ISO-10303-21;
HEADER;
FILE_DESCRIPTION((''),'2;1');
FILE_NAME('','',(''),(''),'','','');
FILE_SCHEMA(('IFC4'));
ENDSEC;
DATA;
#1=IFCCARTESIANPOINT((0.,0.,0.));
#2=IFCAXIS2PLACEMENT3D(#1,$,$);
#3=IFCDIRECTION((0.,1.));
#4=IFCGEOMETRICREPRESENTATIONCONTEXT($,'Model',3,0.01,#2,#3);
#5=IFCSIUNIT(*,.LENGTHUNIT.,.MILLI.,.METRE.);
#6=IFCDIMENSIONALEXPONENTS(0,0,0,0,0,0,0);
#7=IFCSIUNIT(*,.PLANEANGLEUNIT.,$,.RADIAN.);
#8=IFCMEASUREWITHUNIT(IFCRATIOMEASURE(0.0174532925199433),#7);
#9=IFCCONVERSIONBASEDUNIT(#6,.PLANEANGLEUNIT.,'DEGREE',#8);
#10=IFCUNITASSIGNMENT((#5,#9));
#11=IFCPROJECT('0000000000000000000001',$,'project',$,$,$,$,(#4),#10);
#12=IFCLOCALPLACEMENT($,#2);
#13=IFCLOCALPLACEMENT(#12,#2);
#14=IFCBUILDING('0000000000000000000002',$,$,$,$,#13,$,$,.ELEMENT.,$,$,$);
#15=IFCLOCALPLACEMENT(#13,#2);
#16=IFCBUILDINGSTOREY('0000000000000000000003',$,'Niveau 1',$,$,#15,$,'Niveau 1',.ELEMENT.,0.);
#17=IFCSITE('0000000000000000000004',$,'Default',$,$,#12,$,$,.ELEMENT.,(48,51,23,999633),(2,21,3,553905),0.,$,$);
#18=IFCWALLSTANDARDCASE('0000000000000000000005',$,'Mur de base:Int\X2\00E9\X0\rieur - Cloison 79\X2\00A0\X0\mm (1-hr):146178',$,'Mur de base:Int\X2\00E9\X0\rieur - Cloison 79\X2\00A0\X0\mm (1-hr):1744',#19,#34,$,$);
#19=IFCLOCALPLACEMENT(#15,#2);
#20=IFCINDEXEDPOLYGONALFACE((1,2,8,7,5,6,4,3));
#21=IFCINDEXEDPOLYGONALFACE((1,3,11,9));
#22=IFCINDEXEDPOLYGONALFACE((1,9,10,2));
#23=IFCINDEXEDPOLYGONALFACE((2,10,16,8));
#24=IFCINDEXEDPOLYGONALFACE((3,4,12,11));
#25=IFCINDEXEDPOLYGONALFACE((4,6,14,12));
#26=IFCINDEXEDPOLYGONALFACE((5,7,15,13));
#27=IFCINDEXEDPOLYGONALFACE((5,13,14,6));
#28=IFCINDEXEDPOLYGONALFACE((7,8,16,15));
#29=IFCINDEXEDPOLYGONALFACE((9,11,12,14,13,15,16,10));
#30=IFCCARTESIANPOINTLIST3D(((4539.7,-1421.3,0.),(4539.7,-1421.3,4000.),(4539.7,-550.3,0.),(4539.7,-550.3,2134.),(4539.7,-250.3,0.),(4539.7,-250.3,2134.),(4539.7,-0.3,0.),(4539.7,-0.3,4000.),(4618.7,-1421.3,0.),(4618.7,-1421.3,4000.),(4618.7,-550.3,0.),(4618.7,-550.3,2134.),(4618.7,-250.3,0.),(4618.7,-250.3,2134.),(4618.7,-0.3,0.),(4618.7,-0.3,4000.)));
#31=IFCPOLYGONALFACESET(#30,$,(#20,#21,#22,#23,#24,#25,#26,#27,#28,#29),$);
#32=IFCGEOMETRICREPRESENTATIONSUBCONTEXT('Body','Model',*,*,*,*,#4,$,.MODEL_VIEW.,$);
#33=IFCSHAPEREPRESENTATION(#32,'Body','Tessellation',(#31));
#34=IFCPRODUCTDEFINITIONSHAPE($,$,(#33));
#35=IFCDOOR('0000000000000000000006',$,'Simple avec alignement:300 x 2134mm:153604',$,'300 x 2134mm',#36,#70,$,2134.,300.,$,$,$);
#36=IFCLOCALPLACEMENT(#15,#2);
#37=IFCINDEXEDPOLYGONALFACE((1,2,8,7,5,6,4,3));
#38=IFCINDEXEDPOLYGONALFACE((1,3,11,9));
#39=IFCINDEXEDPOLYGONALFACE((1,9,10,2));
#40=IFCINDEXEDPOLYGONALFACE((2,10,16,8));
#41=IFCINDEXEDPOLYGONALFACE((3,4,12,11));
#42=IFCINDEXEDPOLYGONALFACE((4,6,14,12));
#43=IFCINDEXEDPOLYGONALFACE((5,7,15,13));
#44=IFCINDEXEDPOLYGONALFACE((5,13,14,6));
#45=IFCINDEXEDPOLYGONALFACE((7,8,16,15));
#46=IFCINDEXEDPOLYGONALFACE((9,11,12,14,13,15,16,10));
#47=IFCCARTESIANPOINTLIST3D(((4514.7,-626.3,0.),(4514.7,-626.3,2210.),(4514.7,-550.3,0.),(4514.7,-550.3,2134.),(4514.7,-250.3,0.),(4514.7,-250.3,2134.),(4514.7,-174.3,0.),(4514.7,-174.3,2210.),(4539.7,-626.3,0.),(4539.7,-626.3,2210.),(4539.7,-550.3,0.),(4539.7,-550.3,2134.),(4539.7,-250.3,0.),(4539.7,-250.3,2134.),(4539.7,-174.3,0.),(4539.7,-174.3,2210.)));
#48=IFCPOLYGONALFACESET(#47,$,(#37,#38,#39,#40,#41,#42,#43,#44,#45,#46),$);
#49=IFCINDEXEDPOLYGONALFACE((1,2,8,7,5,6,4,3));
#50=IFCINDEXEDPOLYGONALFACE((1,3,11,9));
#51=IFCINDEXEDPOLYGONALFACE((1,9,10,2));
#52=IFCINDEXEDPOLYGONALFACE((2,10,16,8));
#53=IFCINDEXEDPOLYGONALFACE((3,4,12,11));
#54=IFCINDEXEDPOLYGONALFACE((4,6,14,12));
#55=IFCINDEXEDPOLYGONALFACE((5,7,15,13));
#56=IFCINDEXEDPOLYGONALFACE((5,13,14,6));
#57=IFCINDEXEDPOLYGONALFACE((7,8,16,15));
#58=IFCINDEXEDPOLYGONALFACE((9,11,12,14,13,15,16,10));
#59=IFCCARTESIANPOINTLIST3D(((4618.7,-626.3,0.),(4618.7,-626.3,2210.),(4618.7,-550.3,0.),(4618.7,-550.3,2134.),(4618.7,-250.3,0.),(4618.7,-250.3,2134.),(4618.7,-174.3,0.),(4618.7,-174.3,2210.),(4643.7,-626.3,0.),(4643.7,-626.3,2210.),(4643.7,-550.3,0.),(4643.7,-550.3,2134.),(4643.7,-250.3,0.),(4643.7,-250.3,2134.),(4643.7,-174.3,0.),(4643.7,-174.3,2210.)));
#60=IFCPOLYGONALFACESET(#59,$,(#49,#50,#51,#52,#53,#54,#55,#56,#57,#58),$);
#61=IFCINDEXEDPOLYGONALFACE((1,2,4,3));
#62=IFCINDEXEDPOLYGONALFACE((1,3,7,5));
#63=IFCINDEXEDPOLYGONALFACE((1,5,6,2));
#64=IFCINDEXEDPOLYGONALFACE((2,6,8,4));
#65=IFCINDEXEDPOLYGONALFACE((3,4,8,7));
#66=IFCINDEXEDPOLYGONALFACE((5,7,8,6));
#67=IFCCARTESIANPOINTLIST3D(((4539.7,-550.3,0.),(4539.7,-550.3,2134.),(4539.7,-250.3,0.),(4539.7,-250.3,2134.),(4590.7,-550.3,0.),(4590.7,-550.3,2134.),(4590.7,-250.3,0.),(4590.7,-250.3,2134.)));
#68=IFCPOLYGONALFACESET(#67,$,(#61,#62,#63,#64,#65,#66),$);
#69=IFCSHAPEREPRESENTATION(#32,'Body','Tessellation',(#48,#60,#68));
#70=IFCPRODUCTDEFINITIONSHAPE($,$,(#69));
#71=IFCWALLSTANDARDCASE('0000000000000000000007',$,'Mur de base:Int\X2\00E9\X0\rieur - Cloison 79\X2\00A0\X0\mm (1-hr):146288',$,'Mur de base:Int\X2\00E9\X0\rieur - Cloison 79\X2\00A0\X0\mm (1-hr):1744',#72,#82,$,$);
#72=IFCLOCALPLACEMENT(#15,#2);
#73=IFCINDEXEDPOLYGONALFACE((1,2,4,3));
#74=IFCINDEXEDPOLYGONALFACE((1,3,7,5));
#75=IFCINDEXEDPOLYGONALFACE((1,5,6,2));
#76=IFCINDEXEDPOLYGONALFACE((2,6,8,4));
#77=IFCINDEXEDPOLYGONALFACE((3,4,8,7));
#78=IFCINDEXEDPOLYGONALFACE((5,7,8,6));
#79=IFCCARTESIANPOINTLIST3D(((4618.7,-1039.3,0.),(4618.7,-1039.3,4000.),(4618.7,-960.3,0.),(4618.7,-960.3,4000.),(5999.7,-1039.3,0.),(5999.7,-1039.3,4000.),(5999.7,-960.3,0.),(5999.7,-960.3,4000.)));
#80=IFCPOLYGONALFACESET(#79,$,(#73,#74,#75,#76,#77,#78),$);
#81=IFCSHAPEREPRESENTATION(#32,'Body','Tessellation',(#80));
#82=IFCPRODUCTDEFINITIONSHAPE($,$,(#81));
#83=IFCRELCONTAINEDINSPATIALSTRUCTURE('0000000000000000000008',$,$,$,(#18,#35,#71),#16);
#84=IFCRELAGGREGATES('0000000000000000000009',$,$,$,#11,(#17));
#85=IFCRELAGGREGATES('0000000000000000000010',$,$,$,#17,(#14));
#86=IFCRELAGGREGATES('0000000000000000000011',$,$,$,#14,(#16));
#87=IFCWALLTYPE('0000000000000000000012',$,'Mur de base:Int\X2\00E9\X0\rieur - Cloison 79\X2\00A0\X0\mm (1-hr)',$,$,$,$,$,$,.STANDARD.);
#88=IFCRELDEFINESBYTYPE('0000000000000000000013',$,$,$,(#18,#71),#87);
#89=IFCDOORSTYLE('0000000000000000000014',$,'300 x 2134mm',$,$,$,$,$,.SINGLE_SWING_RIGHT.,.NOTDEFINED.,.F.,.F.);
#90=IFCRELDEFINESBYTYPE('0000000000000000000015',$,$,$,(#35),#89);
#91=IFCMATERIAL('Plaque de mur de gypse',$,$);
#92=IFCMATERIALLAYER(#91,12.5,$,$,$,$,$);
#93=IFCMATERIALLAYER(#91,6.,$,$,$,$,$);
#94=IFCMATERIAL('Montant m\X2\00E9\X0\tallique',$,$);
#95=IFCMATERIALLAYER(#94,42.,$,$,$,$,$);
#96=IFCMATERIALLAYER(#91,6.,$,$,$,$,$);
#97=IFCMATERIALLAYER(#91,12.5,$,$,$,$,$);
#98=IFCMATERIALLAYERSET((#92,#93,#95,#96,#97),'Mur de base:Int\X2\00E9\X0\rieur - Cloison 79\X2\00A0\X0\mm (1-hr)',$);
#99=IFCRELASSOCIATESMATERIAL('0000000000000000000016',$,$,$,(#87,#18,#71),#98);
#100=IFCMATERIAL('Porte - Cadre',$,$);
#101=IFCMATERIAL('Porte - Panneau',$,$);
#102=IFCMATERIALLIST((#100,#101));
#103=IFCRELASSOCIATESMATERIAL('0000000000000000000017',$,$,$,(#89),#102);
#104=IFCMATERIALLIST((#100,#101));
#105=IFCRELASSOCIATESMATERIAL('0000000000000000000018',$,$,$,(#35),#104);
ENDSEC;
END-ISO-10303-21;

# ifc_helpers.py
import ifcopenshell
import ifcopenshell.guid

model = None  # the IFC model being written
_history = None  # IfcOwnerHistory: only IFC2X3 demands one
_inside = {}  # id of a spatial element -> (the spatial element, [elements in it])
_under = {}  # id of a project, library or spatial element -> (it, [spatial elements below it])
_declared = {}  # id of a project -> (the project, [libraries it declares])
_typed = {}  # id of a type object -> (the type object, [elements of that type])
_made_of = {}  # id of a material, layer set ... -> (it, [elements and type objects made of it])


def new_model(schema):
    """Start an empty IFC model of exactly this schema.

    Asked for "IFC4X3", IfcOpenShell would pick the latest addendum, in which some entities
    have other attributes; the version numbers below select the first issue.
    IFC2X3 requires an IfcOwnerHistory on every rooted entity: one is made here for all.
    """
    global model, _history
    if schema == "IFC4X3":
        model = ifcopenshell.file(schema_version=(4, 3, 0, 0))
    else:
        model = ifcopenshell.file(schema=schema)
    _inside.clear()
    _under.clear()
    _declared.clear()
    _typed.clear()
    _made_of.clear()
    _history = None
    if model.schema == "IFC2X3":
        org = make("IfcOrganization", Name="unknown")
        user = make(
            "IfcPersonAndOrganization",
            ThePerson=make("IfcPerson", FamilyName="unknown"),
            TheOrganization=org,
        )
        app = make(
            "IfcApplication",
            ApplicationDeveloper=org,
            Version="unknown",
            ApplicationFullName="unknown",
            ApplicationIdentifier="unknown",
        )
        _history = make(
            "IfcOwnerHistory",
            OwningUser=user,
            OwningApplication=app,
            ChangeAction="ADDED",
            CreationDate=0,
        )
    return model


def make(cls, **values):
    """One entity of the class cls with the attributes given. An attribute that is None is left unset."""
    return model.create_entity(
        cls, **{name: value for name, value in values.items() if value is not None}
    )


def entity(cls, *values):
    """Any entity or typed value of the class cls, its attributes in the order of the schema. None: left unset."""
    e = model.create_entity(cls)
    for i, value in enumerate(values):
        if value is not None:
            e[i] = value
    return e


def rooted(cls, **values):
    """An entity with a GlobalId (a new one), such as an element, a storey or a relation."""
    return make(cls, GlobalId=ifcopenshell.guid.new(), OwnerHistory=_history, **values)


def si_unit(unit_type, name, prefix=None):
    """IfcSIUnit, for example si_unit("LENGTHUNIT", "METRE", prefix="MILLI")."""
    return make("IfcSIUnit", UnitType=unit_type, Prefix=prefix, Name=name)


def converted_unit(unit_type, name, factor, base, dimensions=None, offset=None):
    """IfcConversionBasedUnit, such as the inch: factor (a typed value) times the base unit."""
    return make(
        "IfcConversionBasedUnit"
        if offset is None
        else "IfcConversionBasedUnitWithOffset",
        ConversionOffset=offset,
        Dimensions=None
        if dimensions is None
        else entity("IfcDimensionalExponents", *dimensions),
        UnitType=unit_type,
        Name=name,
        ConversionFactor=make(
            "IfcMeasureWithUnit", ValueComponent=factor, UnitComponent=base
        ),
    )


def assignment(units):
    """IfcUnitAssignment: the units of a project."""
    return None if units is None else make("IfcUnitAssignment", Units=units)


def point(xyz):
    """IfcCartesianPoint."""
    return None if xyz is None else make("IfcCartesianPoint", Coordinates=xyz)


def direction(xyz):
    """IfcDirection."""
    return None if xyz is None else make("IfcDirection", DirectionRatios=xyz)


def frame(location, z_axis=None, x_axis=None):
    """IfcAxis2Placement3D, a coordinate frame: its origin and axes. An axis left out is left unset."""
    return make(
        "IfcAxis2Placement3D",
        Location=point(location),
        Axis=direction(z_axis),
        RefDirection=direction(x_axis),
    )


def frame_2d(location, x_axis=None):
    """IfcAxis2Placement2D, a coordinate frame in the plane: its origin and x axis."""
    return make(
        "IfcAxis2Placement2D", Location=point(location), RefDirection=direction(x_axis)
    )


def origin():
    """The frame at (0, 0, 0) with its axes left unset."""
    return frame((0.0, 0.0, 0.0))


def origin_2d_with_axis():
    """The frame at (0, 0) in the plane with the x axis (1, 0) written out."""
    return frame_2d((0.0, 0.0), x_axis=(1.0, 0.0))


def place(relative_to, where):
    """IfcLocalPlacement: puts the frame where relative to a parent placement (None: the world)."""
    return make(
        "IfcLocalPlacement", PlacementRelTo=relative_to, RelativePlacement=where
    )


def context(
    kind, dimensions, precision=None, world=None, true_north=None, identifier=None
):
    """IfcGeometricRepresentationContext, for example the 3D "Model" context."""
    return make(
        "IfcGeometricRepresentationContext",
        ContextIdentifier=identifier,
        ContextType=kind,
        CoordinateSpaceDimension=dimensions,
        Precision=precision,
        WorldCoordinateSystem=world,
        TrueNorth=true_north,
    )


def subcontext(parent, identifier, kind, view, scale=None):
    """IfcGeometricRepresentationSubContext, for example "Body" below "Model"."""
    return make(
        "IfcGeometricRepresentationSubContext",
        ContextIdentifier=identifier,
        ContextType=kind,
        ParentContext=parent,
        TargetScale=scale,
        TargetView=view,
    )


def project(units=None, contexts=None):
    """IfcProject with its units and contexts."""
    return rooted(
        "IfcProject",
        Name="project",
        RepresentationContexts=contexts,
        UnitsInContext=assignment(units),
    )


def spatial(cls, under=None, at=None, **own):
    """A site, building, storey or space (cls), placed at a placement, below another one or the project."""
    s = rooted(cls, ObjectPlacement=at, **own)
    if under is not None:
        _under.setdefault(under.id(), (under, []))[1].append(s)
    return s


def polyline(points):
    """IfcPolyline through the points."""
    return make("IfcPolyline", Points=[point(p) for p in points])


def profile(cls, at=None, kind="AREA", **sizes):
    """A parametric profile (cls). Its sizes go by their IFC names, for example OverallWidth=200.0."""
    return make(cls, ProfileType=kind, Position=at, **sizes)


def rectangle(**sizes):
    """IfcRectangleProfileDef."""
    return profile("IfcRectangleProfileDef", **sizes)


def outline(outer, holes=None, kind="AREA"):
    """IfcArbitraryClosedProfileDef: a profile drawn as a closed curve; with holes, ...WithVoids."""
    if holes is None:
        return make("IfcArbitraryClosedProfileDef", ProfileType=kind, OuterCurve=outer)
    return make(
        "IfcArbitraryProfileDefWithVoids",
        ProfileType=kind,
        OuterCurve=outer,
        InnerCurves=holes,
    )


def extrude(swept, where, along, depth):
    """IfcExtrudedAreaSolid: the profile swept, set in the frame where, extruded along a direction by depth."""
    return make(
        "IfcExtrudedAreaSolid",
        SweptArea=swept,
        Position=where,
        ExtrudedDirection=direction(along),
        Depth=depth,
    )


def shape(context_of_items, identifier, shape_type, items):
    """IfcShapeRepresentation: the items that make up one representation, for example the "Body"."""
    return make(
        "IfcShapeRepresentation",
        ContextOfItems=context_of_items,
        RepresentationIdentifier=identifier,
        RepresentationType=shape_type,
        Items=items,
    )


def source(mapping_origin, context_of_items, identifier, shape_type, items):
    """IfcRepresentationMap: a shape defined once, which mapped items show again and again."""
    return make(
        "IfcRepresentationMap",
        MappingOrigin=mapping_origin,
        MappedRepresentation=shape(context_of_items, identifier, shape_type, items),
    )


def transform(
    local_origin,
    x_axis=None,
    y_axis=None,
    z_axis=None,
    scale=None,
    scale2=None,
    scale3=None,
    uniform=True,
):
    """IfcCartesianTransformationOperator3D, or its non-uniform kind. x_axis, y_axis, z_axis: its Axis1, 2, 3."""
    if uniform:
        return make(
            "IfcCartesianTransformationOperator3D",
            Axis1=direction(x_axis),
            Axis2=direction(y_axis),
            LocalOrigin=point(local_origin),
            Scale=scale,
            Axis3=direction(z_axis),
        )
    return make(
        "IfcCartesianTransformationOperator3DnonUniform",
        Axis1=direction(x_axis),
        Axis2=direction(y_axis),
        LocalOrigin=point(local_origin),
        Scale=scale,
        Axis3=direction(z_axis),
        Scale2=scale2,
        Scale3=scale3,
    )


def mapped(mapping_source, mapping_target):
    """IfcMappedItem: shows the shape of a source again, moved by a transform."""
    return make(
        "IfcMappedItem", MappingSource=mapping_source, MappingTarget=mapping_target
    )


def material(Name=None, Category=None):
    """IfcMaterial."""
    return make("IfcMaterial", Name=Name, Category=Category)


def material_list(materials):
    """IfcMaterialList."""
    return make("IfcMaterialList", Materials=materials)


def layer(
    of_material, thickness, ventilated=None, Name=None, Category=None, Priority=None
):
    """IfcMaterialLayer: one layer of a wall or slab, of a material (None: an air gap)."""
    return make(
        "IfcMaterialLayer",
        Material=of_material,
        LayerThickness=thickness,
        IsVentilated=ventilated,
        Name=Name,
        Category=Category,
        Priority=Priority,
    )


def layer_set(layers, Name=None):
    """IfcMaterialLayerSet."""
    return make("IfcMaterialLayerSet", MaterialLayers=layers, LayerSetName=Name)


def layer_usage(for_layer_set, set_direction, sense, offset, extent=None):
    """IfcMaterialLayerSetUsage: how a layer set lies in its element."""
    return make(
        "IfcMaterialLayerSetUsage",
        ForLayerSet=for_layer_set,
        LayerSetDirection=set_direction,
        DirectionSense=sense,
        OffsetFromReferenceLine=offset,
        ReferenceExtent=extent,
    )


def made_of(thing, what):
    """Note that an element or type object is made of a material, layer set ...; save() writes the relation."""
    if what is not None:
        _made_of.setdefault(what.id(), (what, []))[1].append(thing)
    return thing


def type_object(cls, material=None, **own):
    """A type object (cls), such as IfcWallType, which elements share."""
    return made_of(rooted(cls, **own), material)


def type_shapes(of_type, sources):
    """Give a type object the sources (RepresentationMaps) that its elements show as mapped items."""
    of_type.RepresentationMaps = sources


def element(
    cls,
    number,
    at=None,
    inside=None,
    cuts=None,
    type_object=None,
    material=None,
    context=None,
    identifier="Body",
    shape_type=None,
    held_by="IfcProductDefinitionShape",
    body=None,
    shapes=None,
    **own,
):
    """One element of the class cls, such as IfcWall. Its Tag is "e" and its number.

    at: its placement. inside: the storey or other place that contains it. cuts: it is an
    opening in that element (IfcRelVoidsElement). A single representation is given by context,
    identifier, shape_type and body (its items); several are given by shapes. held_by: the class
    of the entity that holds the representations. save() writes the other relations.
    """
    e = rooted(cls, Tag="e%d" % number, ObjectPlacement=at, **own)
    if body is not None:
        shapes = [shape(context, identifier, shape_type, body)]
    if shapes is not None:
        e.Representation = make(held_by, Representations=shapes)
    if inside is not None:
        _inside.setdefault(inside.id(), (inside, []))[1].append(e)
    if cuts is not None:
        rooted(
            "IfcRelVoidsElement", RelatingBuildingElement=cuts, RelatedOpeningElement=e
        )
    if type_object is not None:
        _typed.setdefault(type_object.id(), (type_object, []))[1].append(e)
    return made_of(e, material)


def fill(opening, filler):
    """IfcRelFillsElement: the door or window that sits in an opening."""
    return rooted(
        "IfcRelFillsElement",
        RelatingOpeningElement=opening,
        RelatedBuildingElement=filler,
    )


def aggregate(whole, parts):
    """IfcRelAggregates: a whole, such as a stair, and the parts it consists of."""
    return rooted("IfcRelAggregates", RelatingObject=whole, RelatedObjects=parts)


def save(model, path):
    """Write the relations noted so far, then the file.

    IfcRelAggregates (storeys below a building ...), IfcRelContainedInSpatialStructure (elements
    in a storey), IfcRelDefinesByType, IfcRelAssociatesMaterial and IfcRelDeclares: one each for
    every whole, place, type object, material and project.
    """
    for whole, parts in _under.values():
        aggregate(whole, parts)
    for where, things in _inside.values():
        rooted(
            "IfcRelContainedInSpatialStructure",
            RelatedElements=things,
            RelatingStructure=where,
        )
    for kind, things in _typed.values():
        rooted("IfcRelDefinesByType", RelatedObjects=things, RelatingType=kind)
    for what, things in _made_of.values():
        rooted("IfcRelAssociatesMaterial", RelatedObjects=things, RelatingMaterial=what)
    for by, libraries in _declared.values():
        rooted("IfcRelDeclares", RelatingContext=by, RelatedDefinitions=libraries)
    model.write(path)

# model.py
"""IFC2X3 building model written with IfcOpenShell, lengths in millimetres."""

from ifc_helpers import new_model, entity, si_unit, converted_unit, direction, frame, frame_2d, origin, origin_2d_with_axis, place, context, subcontext, project, spatial, polyline, rectangle, outline, extrude, source, transform, mapped, material, material_list, layer, layer_set, layer_usage, type_object, type_shapes, element, fill, save


model = new_model("IFC2X3")

# Units and contexts
model_context = context("Model", 3, precision=0.01, world=origin(), true_north=direction((0.0, 1.0)))
body_context = subcontext(model_context, "Body", "Model", "MODEL_VIEW")
ifc_project = project(units=[si_unit("LENGTHUNIT", "METRE", prefix="MILLI"), converted_unit("PLANEANGLEUNIT", "DEGREE", entity("IfcRatioMeasure", 0.0174532925199433), si_unit("PLANEANGLEUNIT", "RADIAN"), dimensions=[0, 0, 0, 0, 0, 0, 0])], contexts=[model_context])

# Site, building, storey
site_placement = place(None, origin())
site = spatial("IfcSite", under=ifc_project, at=site_placement, Name="Default", CompositionType="ELEMENT", RefLatitude=(48, 51, 23, 999633), RefLongitude=(2, 21, 3, 553905), RefElevation=0.0)
building_placement = place(site_placement, origin())
building = spatial("IfcBuilding", under=site, at=building_placement, CompositionType="ELEMENT")
storey_placement = place(building_placement, origin())
storey = spatial("IfcBuildingStorey", under=building, at=storey_placement, Name="Niveau 1", LongName="Niveau 1", CompositionType="ELEMENT", Elevation=0.0)

# Shared definitions
ifc_material_1 = material(Name="Plaque de mur de gypse")
ifc_layer_1 = layer(ifc_material_1, 12.5)
ifc_layer_2 = layer(ifc_material_1, 6.0)
ifc_material_2 = material(Name="Montant métallique")
ifc_layer_3 = layer(ifc_material_2, 42.0)
ifc_layer_4 = layer(ifc_material_1, 6.0)
ifc_layer_5 = layer(ifc_material_1, 12.5)
ifc_layer_set_1 = layer_set([ifc_layer_1, ifc_layer_2, ifc_layer_3, ifc_layer_4, ifc_layer_5], Name="Mur de base:Intérieur - Cloison 79 mm (1-hr)")
wall_type_1 = type_object("IfcWallType", Name="Mur de base:Intérieur - Cloison 79 mm (1-hr)", PredefinedType="STANDARD", material=ifc_layer_set_1)
ifc_material_3 = material(Name="Porte - Cadre")
ifc_material_4 = material(Name="Porte - Panneau")
ifc_material_list_1 = material_list([ifc_material_3, ifc_material_4])
door_style_1 = type_object("IfcDoorStyle", Name="300 x 2134mm", ConstructionType="NOTDEFINED", OperationType="SINGLE_SWING_RIGHT", ParameterTakesPrecedence=False, Sizeable=False, material=ifc_material_list_1)
shared_shape_1 = source(origin(), body_context, "Body", "SweptSolid", [
    extrude(outline(polyline([(-226.0, -1124.0), (226.0, -1124.0), (226.0, 1086.0), (150.0, 1086.0), (150.0, -1048.0), (-150.0, -1048.0), (-150.0, 1086.0), (-226.0, 1086.0), (-226.0, -1124.0)])), frame((150.0, 79.0, 1086.0), z_axis=(0.0, 1.0, 0.0), x_axis=(1.0, 0.0, 0.0)), (0.0, 0.0, 1.0), 25.0),
    extrude(outline(polyline([(-1124.0, -226.0), (1086.0, -226.0), (1086.0, -150.0), (-1048.0, -150.0), (-1048.0, 150.0), (1086.0, 150.0), (1086.0, 226.0), (-1124.0, 226.0), (-1124.0, -226.0)])), frame((150.0, -25.0, 1086.0), z_axis=(0.0, 1.0, 0.0), x_axis=(0.0, 0.0, -1.0)), (0.0, 0.0, 1.0), 25.0),
    extrude(rectangle(XDim=51.0, YDim=300.0, at=origin_2d_with_axis()), frame((150.0, 53.5, 0.0), z_axis=(0.0, 0.0, 1.0), x_axis=(0.0, 1.0, 0.0)), (0.0, 0.0, 1.0), 2134.0),
])
type_shapes(door_style_1, [shared_shape_1])

# Wall, opening, door
ifc_layer_usage_1 = layer_usage(ifc_layer_set_1, "AXIS2", "NEGATIVE", 39.5)
wall_1_placement = place(storey_placement, frame((4579.2, -1421.3, 0.0), z_axis=(0.0, 0.0, 1.0), x_axis=(0.0, 1.0, 0.0)))
wall_1 = element("IfcWallStandardCase", 1, at=wall_1_placement, inside=storey, type_object=wall_type_1, material=ifc_layer_usage_1, Name="Mur de base:Intérieur - Cloison 79 mm (1-hr):146178", ObjectType="Mur de base:Intérieur - Cloison 79 mm (1-hr):1744", context=body_context, shape_type="SweptSolid", body=[
    extrude(rectangle(XDim=1421.0, YDim=79.0, at=frame_2d((710.5, 0.0), x_axis=(-1.0, 0.0))), origin(), (0.0, 0.0, 1.0), 4000.0),
])
opening_1_placement = place(wall_1_placement, frame((871.0, -39.5, 0.0)))
opening_1 = element("IfcOpeningElement", 2, at=opening_1_placement, cuts=wall_1, ObjectType="Opening", context=body_context, shape_type="SweptSolid", body=[
    extrude(rectangle(XDim=300.0, YDim=2134.0, at=frame_2d((1067.0, 150.0), x_axis=(0.0, 1.0))), frame((0.0, 0.0, 0.0), z_axis=(0.0, 1.0, 0.0), x_axis=(0.0, 0.0, 1.0)), (0.0, 0.0, 1.0), 79.0),
])
ifc_material_list_2 = material_list([ifc_material_3, ifc_material_4])
door_1_placement = place(opening_1_placement, origin())
door_1 = element("IfcDoor", 3, at=door_1_placement, inside=storey, type_object=door_style_1, material=ifc_material_list_2, Name="Simple avec alignement:300 x 2134mm:153604", ObjectType="300 x 2134mm", OverallHeight=2134.0, OverallWidth=300.0, context=body_context, shape_type="MappedRepresentation", body=[
    mapped(shared_shape_1, transform((0.0, 0.0, 0.0), scale=1.0)),
])
fill(opening_1, door_1)

# Wall
ifc_layer_usage_2 = layer_usage(ifc_layer_set_1, "AXIS2", "NEGATIVE", 39.5)
wall_2_placement = place(storey_placement, frame((4618.7, -999.8, 0.0)))
element("IfcWallStandardCase", 4, at=wall_2_placement, inside=storey, type_object=wall_type_1, material=ifc_layer_usage_2, Name="Mur de base:Intérieur - Cloison 79 mm (1-hr):146288", ObjectType="Mur de base:Intérieur - Cloison 79 mm (1-hr):1744", context=body_context, shape_type="SweptSolid", body=[
    extrude(rectangle(XDim=1381.0, YDim=79.0, at=frame_2d((690.5, 0.0), x_axis=(-1.0, 0.0))), origin(), (0.0, 0.0, 1.0), 4000.0),
])

save(model, "model.ifc")
